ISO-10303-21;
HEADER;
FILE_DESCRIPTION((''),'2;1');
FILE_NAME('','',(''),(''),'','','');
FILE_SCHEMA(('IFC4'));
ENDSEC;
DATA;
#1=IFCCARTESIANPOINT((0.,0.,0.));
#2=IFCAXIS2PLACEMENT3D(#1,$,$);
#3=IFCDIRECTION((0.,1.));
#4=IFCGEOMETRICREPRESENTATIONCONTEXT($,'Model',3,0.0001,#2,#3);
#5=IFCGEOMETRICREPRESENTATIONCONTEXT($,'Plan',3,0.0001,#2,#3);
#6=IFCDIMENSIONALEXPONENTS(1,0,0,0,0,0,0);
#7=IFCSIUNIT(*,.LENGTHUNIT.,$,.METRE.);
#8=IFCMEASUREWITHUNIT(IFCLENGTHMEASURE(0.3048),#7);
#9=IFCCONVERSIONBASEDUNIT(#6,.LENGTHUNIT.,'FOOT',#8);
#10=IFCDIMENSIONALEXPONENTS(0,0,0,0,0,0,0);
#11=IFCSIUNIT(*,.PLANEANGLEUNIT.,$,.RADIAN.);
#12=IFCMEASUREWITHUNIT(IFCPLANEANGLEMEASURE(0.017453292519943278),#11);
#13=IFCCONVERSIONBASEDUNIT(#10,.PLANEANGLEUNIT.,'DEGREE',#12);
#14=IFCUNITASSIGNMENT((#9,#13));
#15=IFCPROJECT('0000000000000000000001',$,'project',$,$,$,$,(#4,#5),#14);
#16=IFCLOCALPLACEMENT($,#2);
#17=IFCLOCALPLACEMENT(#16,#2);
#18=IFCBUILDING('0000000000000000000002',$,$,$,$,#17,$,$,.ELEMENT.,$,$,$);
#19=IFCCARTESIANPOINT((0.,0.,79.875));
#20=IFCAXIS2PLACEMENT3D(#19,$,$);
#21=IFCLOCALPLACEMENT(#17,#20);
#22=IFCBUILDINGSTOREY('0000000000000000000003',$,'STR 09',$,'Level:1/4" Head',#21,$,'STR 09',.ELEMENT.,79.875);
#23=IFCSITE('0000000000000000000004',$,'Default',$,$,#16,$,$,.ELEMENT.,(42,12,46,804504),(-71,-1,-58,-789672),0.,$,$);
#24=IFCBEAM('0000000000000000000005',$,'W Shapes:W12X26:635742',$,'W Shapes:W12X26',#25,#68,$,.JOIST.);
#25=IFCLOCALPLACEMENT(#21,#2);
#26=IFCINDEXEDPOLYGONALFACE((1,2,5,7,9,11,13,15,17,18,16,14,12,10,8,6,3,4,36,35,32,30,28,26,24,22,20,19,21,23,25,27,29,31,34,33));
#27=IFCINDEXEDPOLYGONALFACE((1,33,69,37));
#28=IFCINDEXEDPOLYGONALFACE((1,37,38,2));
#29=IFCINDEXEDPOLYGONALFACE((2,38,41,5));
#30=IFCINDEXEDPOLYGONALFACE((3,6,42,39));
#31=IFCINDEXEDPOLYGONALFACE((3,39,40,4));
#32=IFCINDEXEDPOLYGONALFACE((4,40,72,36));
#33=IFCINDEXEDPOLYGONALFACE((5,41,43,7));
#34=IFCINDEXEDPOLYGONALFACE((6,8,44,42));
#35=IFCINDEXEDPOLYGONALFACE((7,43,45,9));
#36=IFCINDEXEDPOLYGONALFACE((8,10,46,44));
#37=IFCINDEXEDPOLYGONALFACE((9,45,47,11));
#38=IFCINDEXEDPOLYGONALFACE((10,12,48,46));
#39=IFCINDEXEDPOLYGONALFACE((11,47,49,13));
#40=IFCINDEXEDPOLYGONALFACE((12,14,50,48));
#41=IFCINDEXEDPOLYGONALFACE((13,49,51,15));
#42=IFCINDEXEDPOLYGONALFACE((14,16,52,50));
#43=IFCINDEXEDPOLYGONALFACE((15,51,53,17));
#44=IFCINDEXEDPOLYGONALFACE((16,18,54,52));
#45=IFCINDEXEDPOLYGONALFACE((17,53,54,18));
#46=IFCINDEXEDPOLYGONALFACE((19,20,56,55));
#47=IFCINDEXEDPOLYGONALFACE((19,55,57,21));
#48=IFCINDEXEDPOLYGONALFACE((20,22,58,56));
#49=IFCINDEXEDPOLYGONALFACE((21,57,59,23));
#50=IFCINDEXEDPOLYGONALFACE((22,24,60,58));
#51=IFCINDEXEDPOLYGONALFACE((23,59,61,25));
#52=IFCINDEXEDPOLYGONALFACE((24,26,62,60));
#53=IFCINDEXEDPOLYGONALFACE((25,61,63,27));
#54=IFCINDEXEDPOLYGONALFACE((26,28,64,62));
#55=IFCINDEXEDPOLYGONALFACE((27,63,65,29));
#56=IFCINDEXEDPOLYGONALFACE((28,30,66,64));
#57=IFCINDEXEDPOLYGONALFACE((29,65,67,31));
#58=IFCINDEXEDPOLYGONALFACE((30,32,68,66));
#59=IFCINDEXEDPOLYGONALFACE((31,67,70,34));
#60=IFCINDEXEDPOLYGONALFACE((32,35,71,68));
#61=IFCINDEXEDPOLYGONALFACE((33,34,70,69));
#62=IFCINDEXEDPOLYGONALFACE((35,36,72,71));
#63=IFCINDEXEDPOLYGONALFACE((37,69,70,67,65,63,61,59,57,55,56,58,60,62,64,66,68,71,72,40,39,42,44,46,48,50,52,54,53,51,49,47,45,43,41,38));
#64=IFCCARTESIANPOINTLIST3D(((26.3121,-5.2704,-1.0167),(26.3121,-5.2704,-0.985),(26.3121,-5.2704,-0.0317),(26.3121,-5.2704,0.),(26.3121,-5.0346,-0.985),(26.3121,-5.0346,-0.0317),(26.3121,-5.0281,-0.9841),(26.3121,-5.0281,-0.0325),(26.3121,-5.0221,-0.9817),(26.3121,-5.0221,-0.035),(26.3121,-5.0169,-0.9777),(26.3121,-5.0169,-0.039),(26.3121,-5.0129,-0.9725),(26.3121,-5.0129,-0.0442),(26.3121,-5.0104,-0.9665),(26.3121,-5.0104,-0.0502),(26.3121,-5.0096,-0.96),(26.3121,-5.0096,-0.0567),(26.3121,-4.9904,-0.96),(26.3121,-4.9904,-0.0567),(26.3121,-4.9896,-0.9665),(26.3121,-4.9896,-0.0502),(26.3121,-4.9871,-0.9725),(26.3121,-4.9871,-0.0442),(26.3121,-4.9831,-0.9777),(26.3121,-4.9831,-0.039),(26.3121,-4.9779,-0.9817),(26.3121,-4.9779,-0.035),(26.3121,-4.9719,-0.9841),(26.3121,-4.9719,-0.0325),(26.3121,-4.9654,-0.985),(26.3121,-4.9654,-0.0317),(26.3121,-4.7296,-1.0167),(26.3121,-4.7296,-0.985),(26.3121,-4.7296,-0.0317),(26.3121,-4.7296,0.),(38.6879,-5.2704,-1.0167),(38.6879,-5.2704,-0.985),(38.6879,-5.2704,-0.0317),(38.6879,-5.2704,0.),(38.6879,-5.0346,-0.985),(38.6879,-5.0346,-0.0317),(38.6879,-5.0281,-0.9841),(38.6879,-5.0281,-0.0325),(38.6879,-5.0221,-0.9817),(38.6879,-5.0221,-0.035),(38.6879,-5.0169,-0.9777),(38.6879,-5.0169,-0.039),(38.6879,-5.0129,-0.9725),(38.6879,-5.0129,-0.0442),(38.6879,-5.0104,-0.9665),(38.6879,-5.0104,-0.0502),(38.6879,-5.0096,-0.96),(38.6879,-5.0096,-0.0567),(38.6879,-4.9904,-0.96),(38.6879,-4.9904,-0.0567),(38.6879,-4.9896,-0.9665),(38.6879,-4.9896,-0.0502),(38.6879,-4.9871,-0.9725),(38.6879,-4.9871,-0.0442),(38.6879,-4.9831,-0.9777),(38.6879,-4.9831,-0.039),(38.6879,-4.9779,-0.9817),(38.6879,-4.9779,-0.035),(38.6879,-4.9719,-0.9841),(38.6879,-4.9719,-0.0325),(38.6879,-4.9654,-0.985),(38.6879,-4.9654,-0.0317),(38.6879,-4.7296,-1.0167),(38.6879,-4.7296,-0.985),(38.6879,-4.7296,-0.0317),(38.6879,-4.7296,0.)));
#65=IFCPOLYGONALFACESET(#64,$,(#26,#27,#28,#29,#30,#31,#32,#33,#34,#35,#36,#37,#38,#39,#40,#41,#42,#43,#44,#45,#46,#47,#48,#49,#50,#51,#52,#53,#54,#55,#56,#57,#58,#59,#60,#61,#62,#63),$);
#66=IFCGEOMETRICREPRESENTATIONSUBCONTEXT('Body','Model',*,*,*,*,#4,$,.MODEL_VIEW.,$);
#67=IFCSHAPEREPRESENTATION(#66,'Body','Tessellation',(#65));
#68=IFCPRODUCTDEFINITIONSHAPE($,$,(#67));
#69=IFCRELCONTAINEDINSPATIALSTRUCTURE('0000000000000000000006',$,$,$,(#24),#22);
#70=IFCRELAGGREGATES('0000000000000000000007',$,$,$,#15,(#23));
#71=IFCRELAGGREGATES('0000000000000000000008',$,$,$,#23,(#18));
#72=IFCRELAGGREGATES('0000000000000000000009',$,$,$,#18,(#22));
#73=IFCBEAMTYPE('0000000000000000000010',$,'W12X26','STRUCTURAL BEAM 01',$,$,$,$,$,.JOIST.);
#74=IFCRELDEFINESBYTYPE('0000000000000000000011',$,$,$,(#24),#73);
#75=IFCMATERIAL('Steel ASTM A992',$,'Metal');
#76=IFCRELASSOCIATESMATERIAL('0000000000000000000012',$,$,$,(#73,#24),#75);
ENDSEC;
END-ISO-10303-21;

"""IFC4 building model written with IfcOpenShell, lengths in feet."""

from ifc_helpers import new_model, entity, si_unit, converted_unit, direction, frame, origin, place, context, subcontext, project, spatial, line, arc, indexed_curve, outline, extrude, source, transform, mapped, material, type_object, type_shapes, element, save


model = new_model("IFC4")

# Units and contexts
model_context = context("Model", 3, precision=0.0001, world=origin(), true_north=direction((0.0, 1.0)))
plan_context = context("Plan", 3, precision=0.0001, world=origin(), true_north=direction((0.0, 1.0)))
body_context = subcontext(model_context, "Body", "Model", "MODEL_VIEW")
ifc_project = project(units=[converted_unit("LENGTHUNIT", "FOOT", entity("IfcLengthMeasure", 0.3048), si_unit("LENGTHUNIT", "METRE"), dimensions=[1, 0, 0, 0, 0, 0, 0]), converted_unit("PLANEANGLEUNIT", "DEGREE", entity("IfcPlaneAngleMeasure", 0.017453292519943278), si_unit("PLANEANGLEUNIT", "RADIAN"), dimensions=[0, 0, 0, 0, 0, 0, 0])], contexts=[model_context, plan_context])

# Site, building, storey
site_placement = place(None, origin())
site = spatial("IfcSite", under=ifc_project, at=site_placement, Name="Default", CompositionType="ELEMENT", RefLatitude=(42, 12, 46, 804504), RefLongitude=(-71, -1, -58, -789672), RefElevation=0.0)
building_placement = place(site_placement, origin())
building = spatial("IfcBuilding", under=site, at=building_placement, CompositionType="ELEMENT")
storey_placement = place(building_placement, frame((0.0, 0.0, 79.875)))
storey = spatial("IfcBuildingStorey", under=building, at=storey_placement, Name="STR 09", ObjectType="Level:1/4\" Head", LongName="STR 09", CompositionType="ELEMENT", Elevation=79.875)

# Shared definitions
ifc_material = material(Name="Steel ASTM A992", Category="Metal")

# Beam
beam_type_1 = type_object("IfcBeamType", Name="W12X26", Description="STRUCTURAL BEAM 01", PredefinedType="JOIST", material=ifc_material)
shared_shape_1 = source(origin(), body_context, "Body", "SweptSolid", [
    extrude(outline(indexed_curve([(0.4767, -0.2704), (0.5083, -0.2704), (0.5083, 0.2704), (0.4767, 0.2704), (0.4767, 0.0346), (0.4693, 0.0169), (0.4517, 0.0096), (-0.4517, 0.0096), (-0.4693, 0.0169), (-0.4767, 0.0346), (-0.4767, 0.2704), (-0.5083, 0.2704), (-0.5083, -0.2704), (-0.4767, -0.2704), (-0.4767, -0.0346), (-0.4693, -0.0169), (-0.4517, -0.0096), (0.4517, -0.0096), (0.4693, -0.0169), (0.4767, -0.0346)], segments=[line(1, 2, 3, 4, 5), arc(5, 6, 7), line(7, 8), arc(8, 9, 10), line(10, 11, 12, 13, 14, 15), arc(15, 16, 17), line(17, 18), arc(18, 19, 20), line(20, 1)], self_intersect=False)), frame((-6.1879, 0.0, 0.0), z_axis=(1.0, 0.0, 0.0), x_axis=(0.0, 0.0, -1.0)), (0.0, 0.0, 1.0), 12.3758),
])
type_shapes(beam_type_1, [shared_shape_1])
beam_1_placement = place(storey_placement, frame((32.5, -5.0, -0.5083)))
element("IfcBeam", 1, at=beam_1_placement, inside=storey, type_object=beam_type_1, material=ifc_material, Name="W Shapes:W12X26:635742", ObjectType="W Shapes:W12X26", PredefinedType="JOIST", context=body_context, shape_type="MappedRepresentation", body=[
    mapped(shared_shape_1, transform((0.0, 0.0, 0.0), scale=1.0)),
])

save(model, "model.ifc")
